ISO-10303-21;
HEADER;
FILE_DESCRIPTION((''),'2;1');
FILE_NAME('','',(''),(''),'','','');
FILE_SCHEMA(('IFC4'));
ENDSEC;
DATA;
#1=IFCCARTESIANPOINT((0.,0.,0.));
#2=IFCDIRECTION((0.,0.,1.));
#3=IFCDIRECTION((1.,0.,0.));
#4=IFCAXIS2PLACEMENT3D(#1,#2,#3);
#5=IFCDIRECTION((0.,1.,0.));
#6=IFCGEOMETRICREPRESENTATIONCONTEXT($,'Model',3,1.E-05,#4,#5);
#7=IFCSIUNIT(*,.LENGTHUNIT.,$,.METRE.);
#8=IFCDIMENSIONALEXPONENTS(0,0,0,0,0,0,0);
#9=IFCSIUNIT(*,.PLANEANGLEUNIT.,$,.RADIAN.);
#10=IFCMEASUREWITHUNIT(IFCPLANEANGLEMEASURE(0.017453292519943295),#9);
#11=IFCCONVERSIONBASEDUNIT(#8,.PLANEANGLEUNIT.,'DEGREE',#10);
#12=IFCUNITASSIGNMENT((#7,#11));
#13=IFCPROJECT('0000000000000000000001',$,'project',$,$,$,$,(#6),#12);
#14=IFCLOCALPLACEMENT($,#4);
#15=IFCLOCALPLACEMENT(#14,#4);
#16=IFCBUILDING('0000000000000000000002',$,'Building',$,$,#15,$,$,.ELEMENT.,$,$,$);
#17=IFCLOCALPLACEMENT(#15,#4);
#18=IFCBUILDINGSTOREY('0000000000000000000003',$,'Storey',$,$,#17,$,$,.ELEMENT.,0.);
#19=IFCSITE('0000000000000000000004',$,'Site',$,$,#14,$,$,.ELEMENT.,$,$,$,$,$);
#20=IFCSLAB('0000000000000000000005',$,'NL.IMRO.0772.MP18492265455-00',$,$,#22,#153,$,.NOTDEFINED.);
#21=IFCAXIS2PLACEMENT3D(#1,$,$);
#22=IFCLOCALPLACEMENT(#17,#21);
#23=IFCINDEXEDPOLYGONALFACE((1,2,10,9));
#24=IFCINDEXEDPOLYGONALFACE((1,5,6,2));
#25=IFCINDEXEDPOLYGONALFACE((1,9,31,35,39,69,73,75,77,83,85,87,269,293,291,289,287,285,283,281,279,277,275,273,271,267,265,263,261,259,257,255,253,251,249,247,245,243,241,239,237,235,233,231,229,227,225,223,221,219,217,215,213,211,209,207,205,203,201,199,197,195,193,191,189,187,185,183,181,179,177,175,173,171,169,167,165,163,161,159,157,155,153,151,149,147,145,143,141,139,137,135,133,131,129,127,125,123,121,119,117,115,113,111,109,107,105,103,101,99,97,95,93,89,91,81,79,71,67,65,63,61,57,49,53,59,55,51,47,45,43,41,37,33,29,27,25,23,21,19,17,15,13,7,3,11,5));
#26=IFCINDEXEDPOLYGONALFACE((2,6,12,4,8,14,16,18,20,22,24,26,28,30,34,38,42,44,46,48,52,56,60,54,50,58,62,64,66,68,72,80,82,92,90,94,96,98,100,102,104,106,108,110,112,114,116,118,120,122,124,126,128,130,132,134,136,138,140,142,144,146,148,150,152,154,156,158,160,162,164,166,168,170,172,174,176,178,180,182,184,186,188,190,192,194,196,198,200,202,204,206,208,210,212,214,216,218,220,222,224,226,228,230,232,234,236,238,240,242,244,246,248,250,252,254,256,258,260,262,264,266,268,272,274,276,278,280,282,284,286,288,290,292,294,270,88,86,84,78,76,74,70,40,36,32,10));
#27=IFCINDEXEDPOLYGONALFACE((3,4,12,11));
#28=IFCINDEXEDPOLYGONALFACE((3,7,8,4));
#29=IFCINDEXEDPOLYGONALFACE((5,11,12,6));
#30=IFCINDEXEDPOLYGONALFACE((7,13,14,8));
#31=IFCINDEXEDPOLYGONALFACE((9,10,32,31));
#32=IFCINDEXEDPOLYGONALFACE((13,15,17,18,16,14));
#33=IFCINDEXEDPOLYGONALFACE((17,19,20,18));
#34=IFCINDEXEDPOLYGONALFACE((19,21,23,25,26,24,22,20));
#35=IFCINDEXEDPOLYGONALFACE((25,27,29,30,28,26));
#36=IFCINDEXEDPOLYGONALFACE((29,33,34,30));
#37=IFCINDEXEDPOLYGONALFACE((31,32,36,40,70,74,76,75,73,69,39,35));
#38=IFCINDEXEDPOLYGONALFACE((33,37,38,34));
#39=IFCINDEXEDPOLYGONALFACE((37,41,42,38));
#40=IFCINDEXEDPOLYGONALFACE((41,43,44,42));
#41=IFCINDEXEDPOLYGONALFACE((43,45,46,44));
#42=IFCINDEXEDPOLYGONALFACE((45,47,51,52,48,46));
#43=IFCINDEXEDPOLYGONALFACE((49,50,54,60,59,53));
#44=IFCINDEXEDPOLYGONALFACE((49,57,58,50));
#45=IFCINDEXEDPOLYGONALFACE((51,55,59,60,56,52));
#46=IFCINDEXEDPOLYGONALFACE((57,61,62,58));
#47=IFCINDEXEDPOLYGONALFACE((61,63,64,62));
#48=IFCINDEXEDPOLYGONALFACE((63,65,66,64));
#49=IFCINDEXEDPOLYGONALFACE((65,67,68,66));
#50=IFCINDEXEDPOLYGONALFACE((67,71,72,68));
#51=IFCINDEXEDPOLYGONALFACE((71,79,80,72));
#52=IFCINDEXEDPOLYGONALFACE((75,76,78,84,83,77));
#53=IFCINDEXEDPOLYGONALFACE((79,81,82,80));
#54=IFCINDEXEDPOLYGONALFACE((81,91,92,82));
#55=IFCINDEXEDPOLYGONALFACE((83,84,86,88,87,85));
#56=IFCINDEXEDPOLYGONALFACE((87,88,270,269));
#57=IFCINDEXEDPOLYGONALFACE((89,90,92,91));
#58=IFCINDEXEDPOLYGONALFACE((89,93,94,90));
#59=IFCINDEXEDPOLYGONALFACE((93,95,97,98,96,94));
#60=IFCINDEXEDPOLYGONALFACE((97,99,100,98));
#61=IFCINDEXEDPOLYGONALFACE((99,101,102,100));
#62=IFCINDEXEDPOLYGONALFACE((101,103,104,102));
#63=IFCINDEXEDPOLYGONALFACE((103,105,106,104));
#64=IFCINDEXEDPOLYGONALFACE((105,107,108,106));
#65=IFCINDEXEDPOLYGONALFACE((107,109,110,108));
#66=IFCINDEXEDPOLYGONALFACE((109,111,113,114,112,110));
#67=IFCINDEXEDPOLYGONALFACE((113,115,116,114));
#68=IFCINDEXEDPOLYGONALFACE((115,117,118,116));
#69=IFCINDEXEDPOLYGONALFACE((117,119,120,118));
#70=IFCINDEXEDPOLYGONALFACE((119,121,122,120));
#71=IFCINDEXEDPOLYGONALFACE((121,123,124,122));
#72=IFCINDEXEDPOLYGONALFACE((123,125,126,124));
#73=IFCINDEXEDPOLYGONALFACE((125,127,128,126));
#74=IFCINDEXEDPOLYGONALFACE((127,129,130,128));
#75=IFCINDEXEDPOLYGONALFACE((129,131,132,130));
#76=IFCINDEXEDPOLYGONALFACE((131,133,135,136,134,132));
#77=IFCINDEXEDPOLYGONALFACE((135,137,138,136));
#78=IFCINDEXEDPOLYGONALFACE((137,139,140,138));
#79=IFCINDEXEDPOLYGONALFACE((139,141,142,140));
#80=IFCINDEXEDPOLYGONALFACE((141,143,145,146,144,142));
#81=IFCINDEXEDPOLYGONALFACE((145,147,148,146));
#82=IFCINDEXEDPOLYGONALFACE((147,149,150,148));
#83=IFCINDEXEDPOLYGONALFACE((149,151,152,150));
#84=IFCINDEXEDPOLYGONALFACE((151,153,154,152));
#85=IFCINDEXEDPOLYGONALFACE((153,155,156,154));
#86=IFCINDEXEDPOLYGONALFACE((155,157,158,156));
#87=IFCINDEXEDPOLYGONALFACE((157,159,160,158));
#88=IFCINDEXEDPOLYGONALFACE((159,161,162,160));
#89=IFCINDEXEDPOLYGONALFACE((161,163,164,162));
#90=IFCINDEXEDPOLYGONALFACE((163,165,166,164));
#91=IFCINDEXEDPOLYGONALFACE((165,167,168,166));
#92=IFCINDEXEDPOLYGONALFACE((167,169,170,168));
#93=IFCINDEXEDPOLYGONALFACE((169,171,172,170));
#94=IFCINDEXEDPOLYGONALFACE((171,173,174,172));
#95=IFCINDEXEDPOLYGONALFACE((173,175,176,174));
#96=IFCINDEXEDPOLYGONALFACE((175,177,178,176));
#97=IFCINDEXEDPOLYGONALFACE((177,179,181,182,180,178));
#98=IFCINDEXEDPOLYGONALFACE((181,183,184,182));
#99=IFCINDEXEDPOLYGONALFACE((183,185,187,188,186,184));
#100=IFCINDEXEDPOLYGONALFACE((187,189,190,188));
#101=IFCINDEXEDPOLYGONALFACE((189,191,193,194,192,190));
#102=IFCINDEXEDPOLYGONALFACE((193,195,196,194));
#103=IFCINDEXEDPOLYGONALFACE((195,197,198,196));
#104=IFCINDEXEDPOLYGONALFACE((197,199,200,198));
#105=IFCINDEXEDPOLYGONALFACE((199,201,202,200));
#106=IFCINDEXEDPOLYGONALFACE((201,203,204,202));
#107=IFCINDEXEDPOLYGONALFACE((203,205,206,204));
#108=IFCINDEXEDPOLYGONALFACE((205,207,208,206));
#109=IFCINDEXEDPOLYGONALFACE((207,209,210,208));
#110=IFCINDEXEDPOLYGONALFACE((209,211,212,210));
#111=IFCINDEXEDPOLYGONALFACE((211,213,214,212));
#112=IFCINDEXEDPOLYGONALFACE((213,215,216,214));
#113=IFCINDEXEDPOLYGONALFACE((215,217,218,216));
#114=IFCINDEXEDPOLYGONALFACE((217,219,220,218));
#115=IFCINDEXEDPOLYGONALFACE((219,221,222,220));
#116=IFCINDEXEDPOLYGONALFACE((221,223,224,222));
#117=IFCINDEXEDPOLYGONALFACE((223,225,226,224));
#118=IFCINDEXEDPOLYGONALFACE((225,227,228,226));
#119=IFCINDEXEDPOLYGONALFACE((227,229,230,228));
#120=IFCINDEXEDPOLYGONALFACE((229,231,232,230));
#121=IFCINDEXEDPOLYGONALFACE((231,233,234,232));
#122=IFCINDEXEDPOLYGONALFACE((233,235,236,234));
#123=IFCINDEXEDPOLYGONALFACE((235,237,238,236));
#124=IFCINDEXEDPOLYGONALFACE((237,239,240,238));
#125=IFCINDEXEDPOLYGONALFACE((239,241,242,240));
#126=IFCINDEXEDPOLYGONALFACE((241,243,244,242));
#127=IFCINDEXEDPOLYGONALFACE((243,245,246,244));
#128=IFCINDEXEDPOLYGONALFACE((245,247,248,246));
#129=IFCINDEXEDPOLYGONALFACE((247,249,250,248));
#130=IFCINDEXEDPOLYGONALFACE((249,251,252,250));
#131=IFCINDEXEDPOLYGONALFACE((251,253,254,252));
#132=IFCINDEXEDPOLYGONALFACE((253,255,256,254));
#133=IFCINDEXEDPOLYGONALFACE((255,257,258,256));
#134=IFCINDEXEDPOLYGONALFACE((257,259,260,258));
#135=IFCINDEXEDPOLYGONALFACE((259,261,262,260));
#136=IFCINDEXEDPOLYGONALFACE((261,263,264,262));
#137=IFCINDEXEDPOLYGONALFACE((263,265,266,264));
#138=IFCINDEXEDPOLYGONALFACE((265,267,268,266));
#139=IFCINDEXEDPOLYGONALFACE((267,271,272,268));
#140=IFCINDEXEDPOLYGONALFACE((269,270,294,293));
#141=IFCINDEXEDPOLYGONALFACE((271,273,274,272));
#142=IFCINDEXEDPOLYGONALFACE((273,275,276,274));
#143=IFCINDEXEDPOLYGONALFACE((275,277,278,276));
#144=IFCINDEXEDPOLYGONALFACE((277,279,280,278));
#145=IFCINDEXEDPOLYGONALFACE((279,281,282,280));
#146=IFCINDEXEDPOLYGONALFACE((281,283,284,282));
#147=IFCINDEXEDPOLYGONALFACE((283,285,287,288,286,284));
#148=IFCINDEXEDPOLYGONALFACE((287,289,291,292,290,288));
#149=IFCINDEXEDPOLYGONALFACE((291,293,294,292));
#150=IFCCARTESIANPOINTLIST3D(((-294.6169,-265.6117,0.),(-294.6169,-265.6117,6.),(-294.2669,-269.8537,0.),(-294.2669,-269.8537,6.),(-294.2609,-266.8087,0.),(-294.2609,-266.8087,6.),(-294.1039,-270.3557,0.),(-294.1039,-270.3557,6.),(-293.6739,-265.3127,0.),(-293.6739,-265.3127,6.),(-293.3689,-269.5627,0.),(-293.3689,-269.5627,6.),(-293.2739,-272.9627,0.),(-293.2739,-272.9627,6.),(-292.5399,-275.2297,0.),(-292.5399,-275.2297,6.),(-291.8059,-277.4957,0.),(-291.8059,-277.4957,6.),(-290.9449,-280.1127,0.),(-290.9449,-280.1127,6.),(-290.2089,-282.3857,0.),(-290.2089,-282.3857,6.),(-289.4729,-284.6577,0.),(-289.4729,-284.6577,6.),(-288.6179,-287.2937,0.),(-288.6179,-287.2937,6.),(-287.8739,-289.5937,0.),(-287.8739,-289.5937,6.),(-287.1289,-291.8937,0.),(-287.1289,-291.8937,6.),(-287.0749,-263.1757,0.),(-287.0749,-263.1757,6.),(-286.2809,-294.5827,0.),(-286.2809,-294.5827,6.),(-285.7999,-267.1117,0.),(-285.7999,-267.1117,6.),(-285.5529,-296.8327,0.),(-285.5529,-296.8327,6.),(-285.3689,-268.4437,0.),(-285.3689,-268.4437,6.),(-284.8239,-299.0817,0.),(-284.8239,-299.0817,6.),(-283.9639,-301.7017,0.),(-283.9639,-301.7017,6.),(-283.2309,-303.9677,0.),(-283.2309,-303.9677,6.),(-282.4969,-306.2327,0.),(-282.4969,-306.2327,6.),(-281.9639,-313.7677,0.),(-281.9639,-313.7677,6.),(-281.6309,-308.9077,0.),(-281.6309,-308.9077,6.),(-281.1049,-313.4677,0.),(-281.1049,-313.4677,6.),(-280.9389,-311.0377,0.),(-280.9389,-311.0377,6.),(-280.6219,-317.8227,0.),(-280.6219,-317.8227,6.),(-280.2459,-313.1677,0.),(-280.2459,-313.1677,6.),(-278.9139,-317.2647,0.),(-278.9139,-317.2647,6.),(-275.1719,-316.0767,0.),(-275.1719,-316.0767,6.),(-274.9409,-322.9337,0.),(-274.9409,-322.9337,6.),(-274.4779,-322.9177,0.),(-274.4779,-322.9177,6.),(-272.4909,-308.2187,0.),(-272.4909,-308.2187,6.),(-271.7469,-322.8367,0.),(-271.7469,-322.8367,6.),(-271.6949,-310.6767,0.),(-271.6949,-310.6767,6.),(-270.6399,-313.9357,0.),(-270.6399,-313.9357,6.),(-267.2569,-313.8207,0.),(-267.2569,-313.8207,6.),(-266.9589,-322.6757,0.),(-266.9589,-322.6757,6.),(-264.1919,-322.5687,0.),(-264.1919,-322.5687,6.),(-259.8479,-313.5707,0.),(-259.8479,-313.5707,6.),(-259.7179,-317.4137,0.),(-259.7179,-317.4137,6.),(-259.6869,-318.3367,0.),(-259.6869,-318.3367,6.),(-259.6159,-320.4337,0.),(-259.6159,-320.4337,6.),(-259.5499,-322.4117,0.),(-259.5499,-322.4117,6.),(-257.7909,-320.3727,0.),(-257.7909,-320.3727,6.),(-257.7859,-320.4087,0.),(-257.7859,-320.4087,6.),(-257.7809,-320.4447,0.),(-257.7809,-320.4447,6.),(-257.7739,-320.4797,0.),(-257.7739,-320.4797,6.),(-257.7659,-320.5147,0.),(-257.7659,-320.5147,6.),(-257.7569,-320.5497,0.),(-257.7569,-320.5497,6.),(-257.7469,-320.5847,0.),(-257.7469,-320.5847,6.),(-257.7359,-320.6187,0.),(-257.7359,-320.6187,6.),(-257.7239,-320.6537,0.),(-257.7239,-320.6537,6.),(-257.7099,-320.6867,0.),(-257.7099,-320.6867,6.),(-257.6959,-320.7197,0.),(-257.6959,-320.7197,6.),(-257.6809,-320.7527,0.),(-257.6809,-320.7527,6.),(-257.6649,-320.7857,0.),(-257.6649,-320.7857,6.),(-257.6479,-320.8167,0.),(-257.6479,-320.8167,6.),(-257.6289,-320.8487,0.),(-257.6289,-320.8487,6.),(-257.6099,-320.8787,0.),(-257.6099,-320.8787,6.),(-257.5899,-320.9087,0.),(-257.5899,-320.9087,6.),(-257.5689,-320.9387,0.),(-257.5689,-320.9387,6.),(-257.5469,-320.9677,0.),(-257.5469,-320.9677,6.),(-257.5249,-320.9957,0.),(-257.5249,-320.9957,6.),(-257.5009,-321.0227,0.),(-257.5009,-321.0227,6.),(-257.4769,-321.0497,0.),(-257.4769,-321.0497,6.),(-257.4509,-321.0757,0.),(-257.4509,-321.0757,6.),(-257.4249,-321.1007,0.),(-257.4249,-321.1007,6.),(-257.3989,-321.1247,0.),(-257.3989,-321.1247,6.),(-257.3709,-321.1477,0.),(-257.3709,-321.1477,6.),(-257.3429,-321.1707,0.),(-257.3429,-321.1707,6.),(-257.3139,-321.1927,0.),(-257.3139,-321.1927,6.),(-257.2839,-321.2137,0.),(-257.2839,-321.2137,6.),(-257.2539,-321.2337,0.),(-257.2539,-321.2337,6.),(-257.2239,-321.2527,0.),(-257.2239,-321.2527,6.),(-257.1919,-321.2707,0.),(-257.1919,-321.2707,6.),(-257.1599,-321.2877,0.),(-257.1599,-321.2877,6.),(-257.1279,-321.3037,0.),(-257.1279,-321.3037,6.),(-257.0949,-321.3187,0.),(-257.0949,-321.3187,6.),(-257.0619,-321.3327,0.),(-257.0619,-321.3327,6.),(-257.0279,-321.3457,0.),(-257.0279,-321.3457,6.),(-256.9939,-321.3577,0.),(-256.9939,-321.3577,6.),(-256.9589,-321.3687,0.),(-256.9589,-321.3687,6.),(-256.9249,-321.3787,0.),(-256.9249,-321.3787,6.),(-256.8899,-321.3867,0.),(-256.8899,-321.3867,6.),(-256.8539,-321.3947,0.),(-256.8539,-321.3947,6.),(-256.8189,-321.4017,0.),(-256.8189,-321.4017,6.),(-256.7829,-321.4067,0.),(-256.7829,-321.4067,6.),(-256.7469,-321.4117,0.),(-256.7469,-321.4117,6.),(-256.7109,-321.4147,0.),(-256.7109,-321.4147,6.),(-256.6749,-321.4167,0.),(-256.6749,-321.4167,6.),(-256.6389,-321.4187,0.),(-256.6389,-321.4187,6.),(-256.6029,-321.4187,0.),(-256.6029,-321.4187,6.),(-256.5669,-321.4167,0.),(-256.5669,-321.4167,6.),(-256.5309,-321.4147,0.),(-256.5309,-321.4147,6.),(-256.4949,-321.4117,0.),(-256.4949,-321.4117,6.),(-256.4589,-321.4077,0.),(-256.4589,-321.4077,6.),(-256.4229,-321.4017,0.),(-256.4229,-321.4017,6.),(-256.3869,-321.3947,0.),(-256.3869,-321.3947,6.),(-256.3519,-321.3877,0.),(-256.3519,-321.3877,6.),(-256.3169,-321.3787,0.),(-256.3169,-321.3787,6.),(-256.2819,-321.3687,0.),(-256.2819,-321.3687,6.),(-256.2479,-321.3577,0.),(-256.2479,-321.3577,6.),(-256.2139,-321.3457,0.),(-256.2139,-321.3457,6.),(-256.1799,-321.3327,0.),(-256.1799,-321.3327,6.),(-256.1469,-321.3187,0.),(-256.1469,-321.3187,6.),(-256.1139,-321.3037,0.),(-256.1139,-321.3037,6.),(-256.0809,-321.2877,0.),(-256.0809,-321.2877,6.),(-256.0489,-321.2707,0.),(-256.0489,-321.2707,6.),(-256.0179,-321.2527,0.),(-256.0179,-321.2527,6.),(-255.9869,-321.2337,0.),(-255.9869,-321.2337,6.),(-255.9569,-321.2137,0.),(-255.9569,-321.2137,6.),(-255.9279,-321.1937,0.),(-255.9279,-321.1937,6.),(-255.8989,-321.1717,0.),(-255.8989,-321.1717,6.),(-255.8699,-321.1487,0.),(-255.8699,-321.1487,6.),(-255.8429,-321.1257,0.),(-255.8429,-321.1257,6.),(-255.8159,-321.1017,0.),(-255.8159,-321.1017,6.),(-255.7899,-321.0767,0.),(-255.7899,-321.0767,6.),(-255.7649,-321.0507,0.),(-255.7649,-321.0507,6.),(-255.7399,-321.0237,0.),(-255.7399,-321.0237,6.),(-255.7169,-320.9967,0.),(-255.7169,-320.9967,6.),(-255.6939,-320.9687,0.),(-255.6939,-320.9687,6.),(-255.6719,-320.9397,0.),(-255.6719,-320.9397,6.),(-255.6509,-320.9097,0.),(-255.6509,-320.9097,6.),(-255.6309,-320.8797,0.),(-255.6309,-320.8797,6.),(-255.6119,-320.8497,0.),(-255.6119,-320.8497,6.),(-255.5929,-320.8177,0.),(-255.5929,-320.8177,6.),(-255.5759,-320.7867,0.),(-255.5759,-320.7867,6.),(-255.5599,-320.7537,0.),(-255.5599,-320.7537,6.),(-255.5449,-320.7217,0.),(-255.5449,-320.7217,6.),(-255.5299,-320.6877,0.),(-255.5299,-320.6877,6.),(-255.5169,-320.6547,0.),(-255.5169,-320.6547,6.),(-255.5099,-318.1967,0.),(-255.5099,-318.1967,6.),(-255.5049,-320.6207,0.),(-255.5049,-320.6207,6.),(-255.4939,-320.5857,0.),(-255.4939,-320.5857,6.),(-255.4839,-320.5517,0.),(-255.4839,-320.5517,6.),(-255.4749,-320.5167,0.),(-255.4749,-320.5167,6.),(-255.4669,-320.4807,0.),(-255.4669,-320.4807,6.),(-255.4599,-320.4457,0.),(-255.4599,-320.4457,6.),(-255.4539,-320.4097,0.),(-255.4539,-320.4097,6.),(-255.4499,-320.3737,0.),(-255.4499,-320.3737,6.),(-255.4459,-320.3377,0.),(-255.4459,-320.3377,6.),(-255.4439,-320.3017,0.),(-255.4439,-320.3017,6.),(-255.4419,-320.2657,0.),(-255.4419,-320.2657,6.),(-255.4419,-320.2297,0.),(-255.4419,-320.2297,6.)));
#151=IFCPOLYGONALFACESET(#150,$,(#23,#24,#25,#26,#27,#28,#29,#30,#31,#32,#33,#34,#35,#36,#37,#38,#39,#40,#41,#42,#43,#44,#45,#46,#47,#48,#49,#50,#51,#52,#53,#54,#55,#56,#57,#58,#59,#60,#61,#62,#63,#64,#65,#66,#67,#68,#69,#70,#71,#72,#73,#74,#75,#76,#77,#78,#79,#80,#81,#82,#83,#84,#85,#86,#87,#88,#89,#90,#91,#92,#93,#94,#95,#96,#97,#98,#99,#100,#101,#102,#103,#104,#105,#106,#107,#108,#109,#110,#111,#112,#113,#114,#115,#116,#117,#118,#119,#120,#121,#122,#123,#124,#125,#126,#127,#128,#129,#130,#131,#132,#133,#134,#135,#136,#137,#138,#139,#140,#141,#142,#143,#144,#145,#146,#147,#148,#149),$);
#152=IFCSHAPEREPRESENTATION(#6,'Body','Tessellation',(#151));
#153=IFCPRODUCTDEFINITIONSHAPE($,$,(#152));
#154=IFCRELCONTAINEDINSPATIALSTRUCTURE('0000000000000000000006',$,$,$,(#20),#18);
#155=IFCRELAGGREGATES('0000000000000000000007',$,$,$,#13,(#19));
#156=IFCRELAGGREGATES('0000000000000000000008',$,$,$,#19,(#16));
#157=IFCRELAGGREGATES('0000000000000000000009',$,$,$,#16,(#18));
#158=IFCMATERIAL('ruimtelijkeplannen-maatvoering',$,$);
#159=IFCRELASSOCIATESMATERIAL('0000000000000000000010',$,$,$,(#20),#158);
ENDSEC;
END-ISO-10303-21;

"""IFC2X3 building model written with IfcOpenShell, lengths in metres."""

from ifc_helpers import new_model, entity, si_unit, converted_unit, direction, origin_with_axes, place, context, project, spatial, polyline, outline, extrude, material, element, save


model = new_model("IFC2X3")

# Units and contexts
model_context = context("Model", 3, precision=1e-05, world=origin_with_axes(), true_north=direction((0.0, 1.0, 0.0)))
ifc_project = project(units=[si_unit("LENGTHUNIT", "METRE"), converted_unit("PLANEANGLEUNIT", "DEGREE", entity("IfcPlaneAngleMeasure", 0.017453292519943295), si_unit("PLANEANGLEUNIT", "RADIAN"), dimensions=[0, 0, 0, 0, 0, 0, 0])], contexts=[model_context])

# Site, building, storey
site_placement = place(None, origin_with_axes())
site = spatial("IfcSite", under=ifc_project, at=site_placement, Name="Site", CompositionType="ELEMENT")
building_placement = place(site_placement, origin_with_axes())
building = spatial("IfcBuilding", under=site, at=building_placement, Name="Building", CompositionType="ELEMENT")
storey_placement = place(building_placement, origin_with_axes())
storey = spatial("IfcBuildingStorey", under=building, at=storey_placement, Name="Storey", CompositionType="ELEMENT", Elevation=0.0)

# Slab
ifc_material = material(Name="ruimtelijkeplannen-maatvoering")
slab_1_placement = place(storey_placement, origin_with_axes())
element("IfcSlab", 1, at=slab_1_placement, inside=storey, material=ifc_material, Name="NL.IMRO.0772.MP18492265455-00", PredefinedType="NOTDEFINED", context=model_context, shape_type="SweptSolid", body=[
    extrude(outline(polyline([(-259.6159, -320.4337), (-259.5499, -322.4117), (-264.1919, -322.5687), (-266.9589, -322.6757), (-271.7469, -322.8367), (-274.4779, -322.9177), (-274.9409, -322.9337), (-275.1719, -316.0767), (-278.9139, -317.2647), (-280.6219, -317.8227), (-281.9639, -313.7677), (-281.1049, -313.4677), (-280.2459, -313.1677), (-280.9389, -311.0377), (-281.6309, -308.9077), (-282.4969, -306.2327), (-283.2309, -303.9677), (-283.9639, -301.7017), (-284.8239, -299.0817), (-285.5529, -296.8327), (-286.2809, -294.5827), (-287.1289, -291.8937), (-287.8739, -289.5937), (-288.6179, -287.2937), (-289.4729, -284.6577), (-290.2089, -282.3857), (-290.9449, -280.1127), (-291.8059, -277.4957), (-292.5399, -275.2297), (-293.2739, -272.9627), (-294.1039, -270.3557), (-294.2669, -269.8537), (-293.3689, -269.5627), (-294.2609, -266.8087), (-294.6169, -265.6117), (-293.6739, -265.3127), (-287.0749, -263.1757), (-285.7999, -267.1117), (-285.3689, -268.4437), (-272.4909, -308.2187), (-271.6949, -310.6767), (-270.6399, -313.9357), (-267.2569, -313.8207), (-259.8479, -313.5707), (-259.7179, -317.4137), (-259.6869, -318.3367), (-255.5099, -318.1967), (-255.4419, -320.2297), (-255.4419, -320.2657), (-255.4439, -320.3017), (-255.4459, -320.3377), (-255.4499, -320.3737), (-255.4539, -320.4097), (-255.4599, -320.4457), (-255.4669, -320.4807), (-255.4749, -320.5167), (-255.4839, -320.5517), (-255.4939, -320.5857), (-255.5049, -320.6207), (-255.5169, -320.6547), (-255.5299, -320.6877), (-255.5449, -320.7217), (-255.5599, -320.7537), (-255.5759, -320.7867), (-255.5929, -320.8177), (-255.6119, -320.8497), (-255.6309, -320.8797), (-255.6509, -320.9097), (-255.6719, -320.9397), (-255.6939, -320.9687), (-255.7169, -320.9967), (-255.7399, -321.0237), (-255.7649, -321.0507), (-255.7899, -321.0767), (-255.8159, -321.1017), (-255.8429, -321.1257), (-255.8699, -321.1487), (-255.8989, -321.1717), (-255.9279, -321.1937), (-255.9569, -321.2137), (-255.9869, -321.2337), (-256.0179, -321.2527), (-256.0489, -321.2707), (-256.0809, -321.2877), (-256.1139, -321.3037), (-256.1469, -321.3187), (-256.1799, -321.3327), (-256.2139, -321.3457), (-256.2479, -321.3577), (-256.2819, -321.3687), (-256.3169, -321.3787), (-256.3519, -321.3877), (-256.3869, -321.3947), (-256.4229, -321.4017), (-256.4589, -321.4077), (-256.4949, -321.4117), (-256.5309, -321.4147), (-256.5669, -321.4167), (-256.6029, -321.4187), (-256.6389, -321.4187), (-256.6749, -321.4167), (-256.7109, -321.4147), (-256.7469, -321.4117), (-256.7829, -321.4067), (-256.8189, -321.4017), (-256.8539, -321.3947), (-256.8899, -321.3867), (-256.9249, -321.3787), (-256.9589, -321.3687), (-256.9939, -321.3577), (-257.0279, -321.3457), (-257.0619, -321.3327), (-257.0949, -321.3187), (-257.1279, -321.3037), (-257.1599, -321.2877), (-257.1919, -321.2707), (-257.2239, -321.2527), (-257.2539, -321.2337), (-257.2839, -321.2137), (-257.3139, -321.1927), (-257.3429, -321.1707), (-257.3709, -321.1477), (-257.3989, -321.1247), (-257.4249, -321.1007), (-257.4509, -321.0757), (-257.4769, -321.0497), (-257.5009, -321.0227), (-257.5249, -320.9957), (-257.5469, -320.9677), (-257.5689, -320.9387), (-257.5899, -320.9087), (-257.6099, -320.8787), (-257.6289, -320.8487), (-257.6479, -320.8167), (-257.6649, -320.7857), (-257.6809, -320.7527), (-257.6959, -320.7197), (-257.7099, -320.6867), (-257.7239, -320.6537), (-257.7359, -320.6187), (-257.7469, -320.5847), (-257.7569, -320.5497), (-257.7659, -320.5147), (-257.7739, -320.4797), (-257.7809, -320.4447), (-257.7859, -320.4087), (-257.7909, -320.3727), (-259.6159, -320.4337)])), origin_with_axes(), (0.0, 0.0, 1.0), 6.0),
])

save(model, "model.ifc")
